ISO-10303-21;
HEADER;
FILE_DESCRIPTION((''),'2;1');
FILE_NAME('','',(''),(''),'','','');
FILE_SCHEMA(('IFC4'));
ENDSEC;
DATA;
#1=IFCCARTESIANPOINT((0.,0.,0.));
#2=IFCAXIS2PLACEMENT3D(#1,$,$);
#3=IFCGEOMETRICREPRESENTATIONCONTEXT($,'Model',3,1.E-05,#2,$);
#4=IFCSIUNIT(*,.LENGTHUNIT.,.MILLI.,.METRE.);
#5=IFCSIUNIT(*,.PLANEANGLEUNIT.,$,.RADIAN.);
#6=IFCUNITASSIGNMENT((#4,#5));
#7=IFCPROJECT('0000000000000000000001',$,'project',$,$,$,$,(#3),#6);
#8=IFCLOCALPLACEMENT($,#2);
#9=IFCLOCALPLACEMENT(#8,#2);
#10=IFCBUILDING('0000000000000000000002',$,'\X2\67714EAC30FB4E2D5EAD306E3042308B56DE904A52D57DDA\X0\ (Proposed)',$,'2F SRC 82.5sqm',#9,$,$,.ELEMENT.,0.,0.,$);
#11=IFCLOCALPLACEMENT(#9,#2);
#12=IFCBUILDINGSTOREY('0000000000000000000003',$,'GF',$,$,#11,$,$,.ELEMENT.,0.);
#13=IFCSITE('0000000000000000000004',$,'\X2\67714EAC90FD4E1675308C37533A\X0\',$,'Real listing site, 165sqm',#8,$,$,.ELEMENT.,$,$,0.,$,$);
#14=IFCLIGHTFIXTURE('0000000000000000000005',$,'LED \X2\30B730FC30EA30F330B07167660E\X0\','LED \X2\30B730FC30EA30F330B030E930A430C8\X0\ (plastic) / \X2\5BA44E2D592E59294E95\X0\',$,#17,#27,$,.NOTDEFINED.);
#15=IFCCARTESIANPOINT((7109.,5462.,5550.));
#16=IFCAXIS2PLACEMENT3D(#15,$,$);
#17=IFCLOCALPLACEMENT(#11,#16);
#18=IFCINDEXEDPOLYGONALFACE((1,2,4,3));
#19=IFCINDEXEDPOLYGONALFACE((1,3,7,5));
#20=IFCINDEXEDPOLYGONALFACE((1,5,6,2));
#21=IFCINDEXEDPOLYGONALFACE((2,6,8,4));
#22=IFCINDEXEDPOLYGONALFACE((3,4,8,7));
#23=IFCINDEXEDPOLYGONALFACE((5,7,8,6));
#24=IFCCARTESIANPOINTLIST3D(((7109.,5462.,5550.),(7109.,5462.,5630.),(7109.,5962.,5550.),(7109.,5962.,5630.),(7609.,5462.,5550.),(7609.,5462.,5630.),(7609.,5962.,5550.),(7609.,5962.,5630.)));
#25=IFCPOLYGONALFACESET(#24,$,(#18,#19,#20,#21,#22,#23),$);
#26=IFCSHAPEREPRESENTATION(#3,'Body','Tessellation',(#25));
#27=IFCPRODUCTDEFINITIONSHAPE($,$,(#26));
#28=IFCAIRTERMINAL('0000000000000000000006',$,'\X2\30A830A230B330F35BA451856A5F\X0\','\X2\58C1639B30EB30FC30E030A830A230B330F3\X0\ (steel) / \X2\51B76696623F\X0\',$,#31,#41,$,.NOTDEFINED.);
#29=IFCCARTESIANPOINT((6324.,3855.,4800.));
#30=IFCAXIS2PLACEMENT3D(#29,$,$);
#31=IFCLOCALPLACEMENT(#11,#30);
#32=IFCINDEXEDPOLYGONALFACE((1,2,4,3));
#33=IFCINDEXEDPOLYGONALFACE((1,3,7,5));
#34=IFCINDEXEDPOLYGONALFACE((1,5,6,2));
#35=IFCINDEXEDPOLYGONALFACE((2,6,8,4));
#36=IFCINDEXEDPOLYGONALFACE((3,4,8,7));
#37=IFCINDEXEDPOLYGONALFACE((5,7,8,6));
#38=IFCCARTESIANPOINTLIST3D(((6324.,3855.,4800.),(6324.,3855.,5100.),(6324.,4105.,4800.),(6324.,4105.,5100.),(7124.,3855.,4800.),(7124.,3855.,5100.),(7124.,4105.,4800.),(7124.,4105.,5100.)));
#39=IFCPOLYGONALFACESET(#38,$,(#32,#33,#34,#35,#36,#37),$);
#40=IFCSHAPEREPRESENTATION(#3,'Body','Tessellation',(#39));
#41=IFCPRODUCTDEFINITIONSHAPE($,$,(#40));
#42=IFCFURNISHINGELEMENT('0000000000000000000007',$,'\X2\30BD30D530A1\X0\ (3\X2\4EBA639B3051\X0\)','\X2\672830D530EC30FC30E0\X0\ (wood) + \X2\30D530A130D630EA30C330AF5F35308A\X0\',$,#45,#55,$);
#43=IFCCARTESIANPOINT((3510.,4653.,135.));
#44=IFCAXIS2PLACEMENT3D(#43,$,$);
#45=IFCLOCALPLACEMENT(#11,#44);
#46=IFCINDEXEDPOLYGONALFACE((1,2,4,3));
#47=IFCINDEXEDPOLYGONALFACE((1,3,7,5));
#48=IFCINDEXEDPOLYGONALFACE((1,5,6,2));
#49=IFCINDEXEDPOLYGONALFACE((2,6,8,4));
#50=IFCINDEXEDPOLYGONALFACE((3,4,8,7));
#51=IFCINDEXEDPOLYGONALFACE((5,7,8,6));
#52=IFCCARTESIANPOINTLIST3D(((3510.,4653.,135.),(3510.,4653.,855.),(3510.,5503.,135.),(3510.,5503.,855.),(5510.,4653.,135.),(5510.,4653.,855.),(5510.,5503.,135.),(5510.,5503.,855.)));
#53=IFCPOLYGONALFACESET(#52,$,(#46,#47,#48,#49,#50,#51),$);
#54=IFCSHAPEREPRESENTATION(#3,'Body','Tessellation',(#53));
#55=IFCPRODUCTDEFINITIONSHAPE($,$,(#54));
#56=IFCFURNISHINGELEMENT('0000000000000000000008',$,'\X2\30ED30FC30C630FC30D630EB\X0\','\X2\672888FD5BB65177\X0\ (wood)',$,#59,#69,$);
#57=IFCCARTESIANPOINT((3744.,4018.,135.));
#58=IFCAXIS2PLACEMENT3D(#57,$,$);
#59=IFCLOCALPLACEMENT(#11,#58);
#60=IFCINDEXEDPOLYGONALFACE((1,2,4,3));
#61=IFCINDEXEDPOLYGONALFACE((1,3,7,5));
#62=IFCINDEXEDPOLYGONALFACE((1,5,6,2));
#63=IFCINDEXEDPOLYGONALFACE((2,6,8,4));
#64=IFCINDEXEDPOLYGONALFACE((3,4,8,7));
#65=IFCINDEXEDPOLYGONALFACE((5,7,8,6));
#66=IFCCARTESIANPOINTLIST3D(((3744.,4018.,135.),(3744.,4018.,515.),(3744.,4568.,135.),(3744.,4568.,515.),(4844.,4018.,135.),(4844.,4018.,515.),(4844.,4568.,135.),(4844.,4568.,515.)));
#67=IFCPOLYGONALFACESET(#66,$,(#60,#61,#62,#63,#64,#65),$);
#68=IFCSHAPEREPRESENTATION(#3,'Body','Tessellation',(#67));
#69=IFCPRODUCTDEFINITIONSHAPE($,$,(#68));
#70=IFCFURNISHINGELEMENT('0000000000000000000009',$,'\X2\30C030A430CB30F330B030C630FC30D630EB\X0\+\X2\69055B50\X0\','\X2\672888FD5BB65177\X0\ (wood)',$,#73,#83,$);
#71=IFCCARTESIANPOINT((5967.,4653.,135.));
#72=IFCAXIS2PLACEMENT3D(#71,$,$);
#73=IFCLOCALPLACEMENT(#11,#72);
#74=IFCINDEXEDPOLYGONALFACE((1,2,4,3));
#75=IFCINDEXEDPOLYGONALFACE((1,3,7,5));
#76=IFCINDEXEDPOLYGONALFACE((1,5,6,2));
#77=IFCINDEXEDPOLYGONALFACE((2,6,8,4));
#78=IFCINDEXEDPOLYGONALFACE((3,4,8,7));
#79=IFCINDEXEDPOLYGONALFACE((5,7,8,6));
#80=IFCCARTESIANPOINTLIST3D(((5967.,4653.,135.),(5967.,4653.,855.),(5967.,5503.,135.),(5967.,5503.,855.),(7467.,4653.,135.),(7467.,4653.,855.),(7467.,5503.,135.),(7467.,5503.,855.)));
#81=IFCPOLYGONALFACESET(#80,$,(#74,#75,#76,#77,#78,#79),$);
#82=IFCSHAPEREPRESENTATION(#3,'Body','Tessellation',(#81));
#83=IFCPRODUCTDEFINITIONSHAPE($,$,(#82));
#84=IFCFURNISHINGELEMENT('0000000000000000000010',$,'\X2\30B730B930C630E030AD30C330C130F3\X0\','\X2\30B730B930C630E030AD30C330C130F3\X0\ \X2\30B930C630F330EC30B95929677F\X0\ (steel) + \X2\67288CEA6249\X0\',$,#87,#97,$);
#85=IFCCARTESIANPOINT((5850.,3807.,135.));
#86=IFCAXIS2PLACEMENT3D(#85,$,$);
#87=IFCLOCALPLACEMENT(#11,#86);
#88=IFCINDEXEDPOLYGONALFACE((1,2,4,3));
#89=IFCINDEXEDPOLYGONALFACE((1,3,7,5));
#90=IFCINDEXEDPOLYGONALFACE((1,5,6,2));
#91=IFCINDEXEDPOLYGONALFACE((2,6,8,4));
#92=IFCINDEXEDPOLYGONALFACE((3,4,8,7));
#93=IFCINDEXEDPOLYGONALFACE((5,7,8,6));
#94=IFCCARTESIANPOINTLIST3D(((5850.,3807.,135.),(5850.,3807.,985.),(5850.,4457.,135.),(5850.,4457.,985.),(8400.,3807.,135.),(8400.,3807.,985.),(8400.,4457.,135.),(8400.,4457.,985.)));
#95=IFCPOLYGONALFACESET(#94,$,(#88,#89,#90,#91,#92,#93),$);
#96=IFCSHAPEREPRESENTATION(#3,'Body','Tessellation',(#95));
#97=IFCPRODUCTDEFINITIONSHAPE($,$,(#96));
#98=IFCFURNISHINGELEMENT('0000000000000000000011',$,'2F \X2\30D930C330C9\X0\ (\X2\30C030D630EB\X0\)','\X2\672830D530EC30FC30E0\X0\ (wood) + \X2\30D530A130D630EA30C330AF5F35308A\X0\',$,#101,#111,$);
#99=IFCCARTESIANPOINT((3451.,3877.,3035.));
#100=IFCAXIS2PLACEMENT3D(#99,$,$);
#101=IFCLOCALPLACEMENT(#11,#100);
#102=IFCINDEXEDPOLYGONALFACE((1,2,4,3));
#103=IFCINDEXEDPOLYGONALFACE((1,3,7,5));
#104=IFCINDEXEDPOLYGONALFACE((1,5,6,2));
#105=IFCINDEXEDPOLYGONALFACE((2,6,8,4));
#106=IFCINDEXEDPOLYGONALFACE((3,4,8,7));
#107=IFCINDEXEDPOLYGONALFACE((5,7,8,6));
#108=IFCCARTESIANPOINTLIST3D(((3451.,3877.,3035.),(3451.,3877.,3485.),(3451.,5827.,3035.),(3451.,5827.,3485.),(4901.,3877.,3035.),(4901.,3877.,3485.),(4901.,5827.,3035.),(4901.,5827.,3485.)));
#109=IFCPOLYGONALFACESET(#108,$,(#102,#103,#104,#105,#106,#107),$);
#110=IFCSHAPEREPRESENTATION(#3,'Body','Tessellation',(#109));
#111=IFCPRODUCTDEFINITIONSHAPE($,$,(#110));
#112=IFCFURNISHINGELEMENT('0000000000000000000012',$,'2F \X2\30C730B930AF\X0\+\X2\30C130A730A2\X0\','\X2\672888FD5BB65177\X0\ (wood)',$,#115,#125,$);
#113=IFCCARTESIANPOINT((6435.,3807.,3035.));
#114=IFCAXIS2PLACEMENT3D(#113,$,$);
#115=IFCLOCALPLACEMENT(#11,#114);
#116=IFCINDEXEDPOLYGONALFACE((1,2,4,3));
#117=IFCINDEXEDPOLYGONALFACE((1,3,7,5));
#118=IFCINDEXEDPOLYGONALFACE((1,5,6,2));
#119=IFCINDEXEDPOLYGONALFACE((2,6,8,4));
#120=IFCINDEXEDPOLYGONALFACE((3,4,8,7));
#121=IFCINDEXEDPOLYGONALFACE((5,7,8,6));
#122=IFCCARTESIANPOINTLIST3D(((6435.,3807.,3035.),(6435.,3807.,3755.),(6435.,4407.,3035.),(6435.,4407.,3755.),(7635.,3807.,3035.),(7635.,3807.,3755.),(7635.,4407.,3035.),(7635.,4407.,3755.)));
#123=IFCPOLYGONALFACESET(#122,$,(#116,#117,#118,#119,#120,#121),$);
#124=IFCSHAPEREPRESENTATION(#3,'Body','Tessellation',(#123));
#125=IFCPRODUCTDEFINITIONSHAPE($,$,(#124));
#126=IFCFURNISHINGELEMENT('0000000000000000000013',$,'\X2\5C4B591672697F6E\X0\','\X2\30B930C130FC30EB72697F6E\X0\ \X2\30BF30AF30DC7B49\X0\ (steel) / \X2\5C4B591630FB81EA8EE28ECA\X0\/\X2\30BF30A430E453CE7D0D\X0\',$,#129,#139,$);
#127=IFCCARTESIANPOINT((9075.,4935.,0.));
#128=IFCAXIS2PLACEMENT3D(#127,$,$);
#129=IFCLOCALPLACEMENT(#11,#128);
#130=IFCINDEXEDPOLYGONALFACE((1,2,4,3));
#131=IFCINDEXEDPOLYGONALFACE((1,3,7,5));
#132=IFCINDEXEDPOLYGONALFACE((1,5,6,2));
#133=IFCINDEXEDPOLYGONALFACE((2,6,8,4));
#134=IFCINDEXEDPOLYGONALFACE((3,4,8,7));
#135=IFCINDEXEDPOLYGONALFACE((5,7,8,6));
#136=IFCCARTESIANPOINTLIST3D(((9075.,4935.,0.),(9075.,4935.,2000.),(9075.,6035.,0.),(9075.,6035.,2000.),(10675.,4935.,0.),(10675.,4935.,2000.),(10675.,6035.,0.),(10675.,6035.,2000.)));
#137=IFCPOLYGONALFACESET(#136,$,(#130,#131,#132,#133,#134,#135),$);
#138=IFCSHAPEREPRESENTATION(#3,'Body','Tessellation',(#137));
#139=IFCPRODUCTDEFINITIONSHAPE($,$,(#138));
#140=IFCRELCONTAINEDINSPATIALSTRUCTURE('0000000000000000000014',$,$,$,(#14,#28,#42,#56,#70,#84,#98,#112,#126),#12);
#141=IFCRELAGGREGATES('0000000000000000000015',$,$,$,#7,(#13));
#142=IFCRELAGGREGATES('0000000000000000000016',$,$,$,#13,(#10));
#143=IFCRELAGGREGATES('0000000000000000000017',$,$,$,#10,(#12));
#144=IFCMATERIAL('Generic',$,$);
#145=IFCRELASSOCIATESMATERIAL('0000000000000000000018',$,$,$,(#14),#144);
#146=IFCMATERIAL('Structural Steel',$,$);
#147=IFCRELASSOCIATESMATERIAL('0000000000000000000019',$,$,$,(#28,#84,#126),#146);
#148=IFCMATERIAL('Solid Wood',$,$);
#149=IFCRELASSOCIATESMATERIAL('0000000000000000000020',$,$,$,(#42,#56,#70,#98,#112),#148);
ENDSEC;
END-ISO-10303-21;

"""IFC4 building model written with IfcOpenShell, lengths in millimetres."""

from ifc_helpers import new_model, si_unit, frame, frame_2d, origin, place, context, project, spatial, rectangle, extrude, material, element, save


model = new_model("IFC4")

# Units and contexts
model_context = context("Model", 3, precision=1e-05, world=origin())
ifc_project = project(units=[si_unit("LENGTHUNIT", "METRE", prefix="MILLI"), si_unit("PLANEANGLEUNIT", "RADIAN")], contexts=[model_context])

# Site, building, storey
site_placement = place(None, origin())
site = spatial("IfcSite", under=ifc_project, at=site_placement, Name="東京都世田谷区", ObjectType="Real listing site, 165sqm", CompositionType="ELEMENT", RefElevation=0.0)
building_placement = place(site_placement, origin())
building = spatial("IfcBuilding", under=site, at=building_placement, Name="東京・中庭のある回遊動線 (Proposed)", ObjectType="2F SRC 82.5sqm", CompositionType="ELEMENT", ElevationOfRefHeight=0.0, ElevationOfTerrain=0.0)
storey_placement = place(building_placement, origin())
storey = spatial("IfcBuildingStorey", under=building, at=storey_placement, Name="GF", CompositionType="ELEMENT", Elevation=0.0)

# Shared definitions
ifc_material_1 = material(Name="Solid Wood")

# Shared definitions
ifc_material_2 = material(Name="Generic")

# Shared definitions
ifc_material_3 = material(Name="Structural Steel")

# Light fixture
light_fixture_placement = place(storey_placement, frame((7109.0, 5462.0, 5550.0)))
element("IfcLightFixture", 1, at=light_fixture_placement, inside=storey, material=ifc_material_2, Name="LED シーリング照明", Description="LED シーリングライト (plastic) / 室中央天井", PredefinedType="NOTDEFINED", context=model_context, shape_type="SweptSolid", body=[
    extrude(rectangle(XDim=500.0, YDim=500.0, at=frame_2d((250.0, 250.0))), frame((7109.0, 5462.0, 5550.0)), (0.0, 0.0, 1.0), 80.0),
])

# Air terminal
air_terminal_1_placement = place(storey_placement, frame((6324.0, 3855.0, 4800.0)))
element("IfcAirTerminal", 2, at=air_terminal_1_placement, inside=storey, material=ifc_material_3, Name="エアコン室内機", Description="壁掛ルームエアコン (steel) / 冷暖房", PredefinedType="NOTDEFINED", context=model_context, shape_type="SweptSolid", body=[
    extrude(rectangle(XDim=800.0, YDim=250.0, at=frame_2d((400.0, 125.0))), frame((6324.0, 3855.0, 4800.0)), (0.0, 0.0, 1.0), 300.0),
])

# Furnishing elements
furnishing_1_placement = place(storey_placement, frame((3510.0, 4653.0, 135.0)))
element("IfcFurnishingElement", 3, at=furnishing_1_placement, inside=storey, material=ifc_material_1, Name="ソファ (3人掛け)", Description="木フレーム (wood) + ファブリック張り", context=model_context, shape_type="SweptSolid", body=[
    extrude(rectangle(XDim=2000.0, YDim=850.0, at=frame_2d((1000.0, 425.0))), frame((3510.0, 4653.0, 135.0)), (0.0, 0.0, 1.0), 720.0),
])
furnishing_2_placement = place(storey_placement, frame((3744.0, 4018.0, 135.0)))
element("IfcFurnishingElement", 4, at=furnishing_2_placement, inside=storey, material=ifc_material_1, Name="ローテーブル", Description="木製家具 (wood)", context=model_context, shape_type="SweptSolid", body=[
    extrude(rectangle(XDim=1100.0, YDim=550.0, at=frame_2d((550.0, 275.0))), frame((3744.0, 4018.0, 135.0)), (0.0, 0.0, 1.0), 380.0),
])
furnishing_3_placement = place(storey_placement, frame((5967.0, 4653.0, 135.0)))
element("IfcFurnishingElement", 5, at=furnishing_3_placement, inside=storey, material=ifc_material_1, Name="ダイニングテーブル+椅子", Description="木製家具 (wood)", context=model_context, shape_type="SweptSolid", body=[
    extrude(rectangle(XDim=1500.0, YDim=850.0, at=frame_2d((750.0, 425.0))), frame((5967.0, 4653.0, 135.0)), (0.0, 0.0, 1.0), 720.0),
])
furnishing_4_placement = place(storey_placement, frame((5850.0, 3807.0, 135.0)))
element("IfcFurnishingElement", 6, at=furnishing_4_placement, inside=storey, material=ifc_material_3, Name="システムキッチン", Description="システムキッチン ステンレス天板 (steel) + 木質扉", context=model_context, shape_type="SweptSolid", body=[
    extrude(rectangle(XDim=2550.0, YDim=650.0, at=frame_2d((1275.0, 325.0))), frame((5850.0, 3807.0, 135.0)), (0.0, 0.0, 1.0), 850.0),
])
furnishing_5_placement = place(storey_placement, frame((3451.0, 3877.0, 3035.0)))
element("IfcFurnishingElement", 7, at=furnishing_5_placement, inside=storey, material=ifc_material_1, Name="2F ベッド (ダブル)", Description="木フレーム (wood) + ファブリック張り", context=model_context, shape_type="SweptSolid", body=[
    extrude(rectangle(XDim=1450.0, YDim=1950.0, at=frame_2d((725.0, 975.0))), frame((3451.0, 3877.0, 3035.0)), (0.0, 0.0, 1.0), 450.0),
])
furnishing_6_placement = place(storey_placement, frame((6435.0, 3807.0, 3035.0)))
element("IfcFurnishingElement", 8, at=furnishing_6_placement, inside=storey, material=ifc_material_1, Name="2F デスク+チェア", Description="木製家具 (wood)", context=model_context, shape_type="SweptSolid", body=[
    extrude(rectangle(XDim=1200.0, YDim=600.0, at=frame_2d((600.0, 300.0))), frame((6435.0, 3807.0, 3035.0)), (0.0, 0.0, 1.0), 720.0),
])
furnishing_7_placement = place(storey_placement, frame((9075.0, 4935.0, 0.0)))
element("IfcFurnishingElement", 9, at=furnishing_7_placement, inside=storey, material=ifc_material_3, Name="屋外物置", Description="スチール物置 タクボ等 (steel) / 屋外・自転車/タイヤ収納", context=model_context, shape_type="SweptSolid", body=[
    extrude(rectangle(XDim=1600.0, YDim=1100.0, at=frame_2d((800.0, 550.0))), frame((9075.0, 4935.0, 0.0)), (0.0, 0.0, 1.0), 2000.0),
])

save(model, "model.ifc")
